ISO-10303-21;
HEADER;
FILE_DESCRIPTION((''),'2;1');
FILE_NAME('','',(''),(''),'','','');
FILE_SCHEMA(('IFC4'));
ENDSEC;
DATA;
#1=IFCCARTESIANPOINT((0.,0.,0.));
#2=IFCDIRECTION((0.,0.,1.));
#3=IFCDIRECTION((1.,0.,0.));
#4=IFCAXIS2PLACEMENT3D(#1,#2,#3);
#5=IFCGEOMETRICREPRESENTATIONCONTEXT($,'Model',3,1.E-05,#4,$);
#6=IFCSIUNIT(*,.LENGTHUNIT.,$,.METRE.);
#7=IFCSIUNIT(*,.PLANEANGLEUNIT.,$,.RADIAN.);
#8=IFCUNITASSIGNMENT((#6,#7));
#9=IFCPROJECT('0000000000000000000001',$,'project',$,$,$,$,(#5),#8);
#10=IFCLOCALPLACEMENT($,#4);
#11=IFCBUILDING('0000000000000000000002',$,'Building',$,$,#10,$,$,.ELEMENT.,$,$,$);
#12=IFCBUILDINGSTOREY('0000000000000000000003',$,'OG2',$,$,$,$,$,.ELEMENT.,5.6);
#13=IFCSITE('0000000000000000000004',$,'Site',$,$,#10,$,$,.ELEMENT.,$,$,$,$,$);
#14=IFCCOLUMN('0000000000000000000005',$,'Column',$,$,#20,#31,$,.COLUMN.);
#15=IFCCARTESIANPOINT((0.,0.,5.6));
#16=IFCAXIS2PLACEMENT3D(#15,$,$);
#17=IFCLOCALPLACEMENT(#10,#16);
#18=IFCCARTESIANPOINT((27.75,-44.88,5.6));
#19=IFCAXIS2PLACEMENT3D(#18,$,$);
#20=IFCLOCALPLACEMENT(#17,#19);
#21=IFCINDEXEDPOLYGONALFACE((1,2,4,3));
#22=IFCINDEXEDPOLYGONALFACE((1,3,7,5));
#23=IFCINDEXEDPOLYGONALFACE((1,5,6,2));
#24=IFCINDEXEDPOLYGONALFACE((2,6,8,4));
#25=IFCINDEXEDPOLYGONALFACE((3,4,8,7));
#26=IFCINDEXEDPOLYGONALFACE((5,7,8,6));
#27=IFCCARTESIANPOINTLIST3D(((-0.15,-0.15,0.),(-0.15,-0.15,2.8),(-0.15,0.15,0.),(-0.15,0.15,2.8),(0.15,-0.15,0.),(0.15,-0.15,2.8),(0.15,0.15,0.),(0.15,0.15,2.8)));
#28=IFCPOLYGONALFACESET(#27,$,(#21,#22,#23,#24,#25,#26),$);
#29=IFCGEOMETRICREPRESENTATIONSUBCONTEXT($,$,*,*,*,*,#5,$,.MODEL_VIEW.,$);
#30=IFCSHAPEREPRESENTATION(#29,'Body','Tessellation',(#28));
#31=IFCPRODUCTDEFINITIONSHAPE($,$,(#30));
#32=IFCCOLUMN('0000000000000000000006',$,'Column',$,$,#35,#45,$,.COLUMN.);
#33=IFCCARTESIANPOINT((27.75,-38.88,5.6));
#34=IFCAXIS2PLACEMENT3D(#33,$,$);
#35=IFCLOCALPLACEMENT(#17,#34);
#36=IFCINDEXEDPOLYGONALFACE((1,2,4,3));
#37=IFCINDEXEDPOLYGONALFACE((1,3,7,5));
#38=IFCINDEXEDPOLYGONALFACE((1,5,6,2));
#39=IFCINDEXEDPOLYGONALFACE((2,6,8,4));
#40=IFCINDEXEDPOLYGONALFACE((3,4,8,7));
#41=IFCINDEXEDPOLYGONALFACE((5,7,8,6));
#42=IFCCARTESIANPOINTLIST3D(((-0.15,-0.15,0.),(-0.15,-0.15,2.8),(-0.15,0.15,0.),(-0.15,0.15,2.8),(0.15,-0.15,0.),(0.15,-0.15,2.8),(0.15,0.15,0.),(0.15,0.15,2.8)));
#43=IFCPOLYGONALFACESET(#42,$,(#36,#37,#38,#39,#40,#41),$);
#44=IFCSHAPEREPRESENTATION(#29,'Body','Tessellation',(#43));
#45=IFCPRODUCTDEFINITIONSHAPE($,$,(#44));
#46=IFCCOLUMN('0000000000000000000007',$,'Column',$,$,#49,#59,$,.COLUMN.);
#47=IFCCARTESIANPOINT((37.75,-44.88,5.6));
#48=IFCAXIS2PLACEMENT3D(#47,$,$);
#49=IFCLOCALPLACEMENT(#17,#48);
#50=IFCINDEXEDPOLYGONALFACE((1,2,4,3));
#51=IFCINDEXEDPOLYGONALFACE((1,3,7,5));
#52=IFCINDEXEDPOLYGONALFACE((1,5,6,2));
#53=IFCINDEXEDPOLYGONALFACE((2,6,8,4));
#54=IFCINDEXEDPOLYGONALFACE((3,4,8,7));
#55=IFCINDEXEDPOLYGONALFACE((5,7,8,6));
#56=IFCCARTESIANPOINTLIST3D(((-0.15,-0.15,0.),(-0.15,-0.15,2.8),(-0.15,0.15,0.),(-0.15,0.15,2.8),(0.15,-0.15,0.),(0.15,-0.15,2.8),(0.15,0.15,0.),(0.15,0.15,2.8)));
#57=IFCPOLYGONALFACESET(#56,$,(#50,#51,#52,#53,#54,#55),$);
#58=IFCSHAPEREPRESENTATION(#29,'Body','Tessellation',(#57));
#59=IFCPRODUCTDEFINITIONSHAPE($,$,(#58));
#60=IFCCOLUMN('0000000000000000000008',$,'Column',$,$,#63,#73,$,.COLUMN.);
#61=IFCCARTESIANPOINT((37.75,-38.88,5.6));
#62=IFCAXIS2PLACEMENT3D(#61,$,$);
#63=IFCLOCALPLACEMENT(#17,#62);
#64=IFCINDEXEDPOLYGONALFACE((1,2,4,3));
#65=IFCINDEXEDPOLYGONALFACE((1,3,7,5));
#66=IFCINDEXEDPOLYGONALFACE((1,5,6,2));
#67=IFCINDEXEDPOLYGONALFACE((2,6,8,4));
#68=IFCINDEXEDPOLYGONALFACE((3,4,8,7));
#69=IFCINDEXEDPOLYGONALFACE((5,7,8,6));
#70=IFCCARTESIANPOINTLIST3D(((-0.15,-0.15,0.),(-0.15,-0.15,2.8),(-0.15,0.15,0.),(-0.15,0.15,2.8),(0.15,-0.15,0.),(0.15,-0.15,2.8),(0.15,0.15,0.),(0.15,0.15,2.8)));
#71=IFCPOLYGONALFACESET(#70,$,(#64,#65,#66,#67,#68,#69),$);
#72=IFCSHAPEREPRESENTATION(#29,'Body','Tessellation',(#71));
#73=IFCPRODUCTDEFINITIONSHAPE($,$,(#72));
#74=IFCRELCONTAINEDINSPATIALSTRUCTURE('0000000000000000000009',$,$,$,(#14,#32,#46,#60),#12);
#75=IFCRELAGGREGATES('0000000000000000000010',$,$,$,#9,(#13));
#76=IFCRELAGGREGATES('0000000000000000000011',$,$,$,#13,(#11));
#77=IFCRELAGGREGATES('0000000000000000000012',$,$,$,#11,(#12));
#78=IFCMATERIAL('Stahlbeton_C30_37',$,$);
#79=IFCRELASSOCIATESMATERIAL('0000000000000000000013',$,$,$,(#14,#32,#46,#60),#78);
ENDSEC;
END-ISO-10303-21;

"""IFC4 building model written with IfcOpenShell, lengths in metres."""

from ifc_helpers import new_model, si_unit, frame, origin, origin_with_axes, origin_2d, place, context, subcontext, project, spatial, rectangle, extrude, material, element, save


model = new_model("IFC4")

# Units and contexts
model_context = context("Model", 3, precision=1e-05, world=origin_with_axes())
sub_context = subcontext(model_context, None, None, "MODEL_VIEW")
ifc_project = project(units=[si_unit("LENGTHUNIT", "METRE"), si_unit("PLANEANGLEUNIT", "RADIAN")], contexts=[model_context])

# Site, building, storey
placement_1 = place(None, origin_with_axes())
site = spatial("IfcSite", under=ifc_project, at=placement_1, Name="Site", CompositionType="ELEMENT")
building = spatial("IfcBuilding", under=site, at=placement_1, Name="Building", CompositionType="ELEMENT")
storey = spatial("IfcBuildingStorey", under=building, Name="OG2", CompositionType="ELEMENT", Elevation=5.6)

# Columns
ifc_material_1 = material(Name="Stahlbeton_C30_37")
placement_2 = place(placement_1, frame((0.0, 0.0, 5.6)))
for number, where, name in (
    (1, (27.75, -44.88, 5.6), "Column"),
    (2, (27.75, -38.88, 5.6), "Column"),
    (3, (37.75, -44.88, 5.6), "Column"),
    (4, (37.75, -38.88, 5.6), "Column"),
):
    element("IfcColumn", number, at=place(placement_2, frame(where)), inside=storey, material=ifc_material_1, Name=name, PredefinedType="COLUMN", context=sub_context, shape_type="SweptSolid", body=[
        extrude(rectangle(XDim=0.3, YDim=0.3, at=origin_2d()), origin(), (0.0, 0.0, 1.0), 2.8),
    ])

save(model, "model.ifc")
